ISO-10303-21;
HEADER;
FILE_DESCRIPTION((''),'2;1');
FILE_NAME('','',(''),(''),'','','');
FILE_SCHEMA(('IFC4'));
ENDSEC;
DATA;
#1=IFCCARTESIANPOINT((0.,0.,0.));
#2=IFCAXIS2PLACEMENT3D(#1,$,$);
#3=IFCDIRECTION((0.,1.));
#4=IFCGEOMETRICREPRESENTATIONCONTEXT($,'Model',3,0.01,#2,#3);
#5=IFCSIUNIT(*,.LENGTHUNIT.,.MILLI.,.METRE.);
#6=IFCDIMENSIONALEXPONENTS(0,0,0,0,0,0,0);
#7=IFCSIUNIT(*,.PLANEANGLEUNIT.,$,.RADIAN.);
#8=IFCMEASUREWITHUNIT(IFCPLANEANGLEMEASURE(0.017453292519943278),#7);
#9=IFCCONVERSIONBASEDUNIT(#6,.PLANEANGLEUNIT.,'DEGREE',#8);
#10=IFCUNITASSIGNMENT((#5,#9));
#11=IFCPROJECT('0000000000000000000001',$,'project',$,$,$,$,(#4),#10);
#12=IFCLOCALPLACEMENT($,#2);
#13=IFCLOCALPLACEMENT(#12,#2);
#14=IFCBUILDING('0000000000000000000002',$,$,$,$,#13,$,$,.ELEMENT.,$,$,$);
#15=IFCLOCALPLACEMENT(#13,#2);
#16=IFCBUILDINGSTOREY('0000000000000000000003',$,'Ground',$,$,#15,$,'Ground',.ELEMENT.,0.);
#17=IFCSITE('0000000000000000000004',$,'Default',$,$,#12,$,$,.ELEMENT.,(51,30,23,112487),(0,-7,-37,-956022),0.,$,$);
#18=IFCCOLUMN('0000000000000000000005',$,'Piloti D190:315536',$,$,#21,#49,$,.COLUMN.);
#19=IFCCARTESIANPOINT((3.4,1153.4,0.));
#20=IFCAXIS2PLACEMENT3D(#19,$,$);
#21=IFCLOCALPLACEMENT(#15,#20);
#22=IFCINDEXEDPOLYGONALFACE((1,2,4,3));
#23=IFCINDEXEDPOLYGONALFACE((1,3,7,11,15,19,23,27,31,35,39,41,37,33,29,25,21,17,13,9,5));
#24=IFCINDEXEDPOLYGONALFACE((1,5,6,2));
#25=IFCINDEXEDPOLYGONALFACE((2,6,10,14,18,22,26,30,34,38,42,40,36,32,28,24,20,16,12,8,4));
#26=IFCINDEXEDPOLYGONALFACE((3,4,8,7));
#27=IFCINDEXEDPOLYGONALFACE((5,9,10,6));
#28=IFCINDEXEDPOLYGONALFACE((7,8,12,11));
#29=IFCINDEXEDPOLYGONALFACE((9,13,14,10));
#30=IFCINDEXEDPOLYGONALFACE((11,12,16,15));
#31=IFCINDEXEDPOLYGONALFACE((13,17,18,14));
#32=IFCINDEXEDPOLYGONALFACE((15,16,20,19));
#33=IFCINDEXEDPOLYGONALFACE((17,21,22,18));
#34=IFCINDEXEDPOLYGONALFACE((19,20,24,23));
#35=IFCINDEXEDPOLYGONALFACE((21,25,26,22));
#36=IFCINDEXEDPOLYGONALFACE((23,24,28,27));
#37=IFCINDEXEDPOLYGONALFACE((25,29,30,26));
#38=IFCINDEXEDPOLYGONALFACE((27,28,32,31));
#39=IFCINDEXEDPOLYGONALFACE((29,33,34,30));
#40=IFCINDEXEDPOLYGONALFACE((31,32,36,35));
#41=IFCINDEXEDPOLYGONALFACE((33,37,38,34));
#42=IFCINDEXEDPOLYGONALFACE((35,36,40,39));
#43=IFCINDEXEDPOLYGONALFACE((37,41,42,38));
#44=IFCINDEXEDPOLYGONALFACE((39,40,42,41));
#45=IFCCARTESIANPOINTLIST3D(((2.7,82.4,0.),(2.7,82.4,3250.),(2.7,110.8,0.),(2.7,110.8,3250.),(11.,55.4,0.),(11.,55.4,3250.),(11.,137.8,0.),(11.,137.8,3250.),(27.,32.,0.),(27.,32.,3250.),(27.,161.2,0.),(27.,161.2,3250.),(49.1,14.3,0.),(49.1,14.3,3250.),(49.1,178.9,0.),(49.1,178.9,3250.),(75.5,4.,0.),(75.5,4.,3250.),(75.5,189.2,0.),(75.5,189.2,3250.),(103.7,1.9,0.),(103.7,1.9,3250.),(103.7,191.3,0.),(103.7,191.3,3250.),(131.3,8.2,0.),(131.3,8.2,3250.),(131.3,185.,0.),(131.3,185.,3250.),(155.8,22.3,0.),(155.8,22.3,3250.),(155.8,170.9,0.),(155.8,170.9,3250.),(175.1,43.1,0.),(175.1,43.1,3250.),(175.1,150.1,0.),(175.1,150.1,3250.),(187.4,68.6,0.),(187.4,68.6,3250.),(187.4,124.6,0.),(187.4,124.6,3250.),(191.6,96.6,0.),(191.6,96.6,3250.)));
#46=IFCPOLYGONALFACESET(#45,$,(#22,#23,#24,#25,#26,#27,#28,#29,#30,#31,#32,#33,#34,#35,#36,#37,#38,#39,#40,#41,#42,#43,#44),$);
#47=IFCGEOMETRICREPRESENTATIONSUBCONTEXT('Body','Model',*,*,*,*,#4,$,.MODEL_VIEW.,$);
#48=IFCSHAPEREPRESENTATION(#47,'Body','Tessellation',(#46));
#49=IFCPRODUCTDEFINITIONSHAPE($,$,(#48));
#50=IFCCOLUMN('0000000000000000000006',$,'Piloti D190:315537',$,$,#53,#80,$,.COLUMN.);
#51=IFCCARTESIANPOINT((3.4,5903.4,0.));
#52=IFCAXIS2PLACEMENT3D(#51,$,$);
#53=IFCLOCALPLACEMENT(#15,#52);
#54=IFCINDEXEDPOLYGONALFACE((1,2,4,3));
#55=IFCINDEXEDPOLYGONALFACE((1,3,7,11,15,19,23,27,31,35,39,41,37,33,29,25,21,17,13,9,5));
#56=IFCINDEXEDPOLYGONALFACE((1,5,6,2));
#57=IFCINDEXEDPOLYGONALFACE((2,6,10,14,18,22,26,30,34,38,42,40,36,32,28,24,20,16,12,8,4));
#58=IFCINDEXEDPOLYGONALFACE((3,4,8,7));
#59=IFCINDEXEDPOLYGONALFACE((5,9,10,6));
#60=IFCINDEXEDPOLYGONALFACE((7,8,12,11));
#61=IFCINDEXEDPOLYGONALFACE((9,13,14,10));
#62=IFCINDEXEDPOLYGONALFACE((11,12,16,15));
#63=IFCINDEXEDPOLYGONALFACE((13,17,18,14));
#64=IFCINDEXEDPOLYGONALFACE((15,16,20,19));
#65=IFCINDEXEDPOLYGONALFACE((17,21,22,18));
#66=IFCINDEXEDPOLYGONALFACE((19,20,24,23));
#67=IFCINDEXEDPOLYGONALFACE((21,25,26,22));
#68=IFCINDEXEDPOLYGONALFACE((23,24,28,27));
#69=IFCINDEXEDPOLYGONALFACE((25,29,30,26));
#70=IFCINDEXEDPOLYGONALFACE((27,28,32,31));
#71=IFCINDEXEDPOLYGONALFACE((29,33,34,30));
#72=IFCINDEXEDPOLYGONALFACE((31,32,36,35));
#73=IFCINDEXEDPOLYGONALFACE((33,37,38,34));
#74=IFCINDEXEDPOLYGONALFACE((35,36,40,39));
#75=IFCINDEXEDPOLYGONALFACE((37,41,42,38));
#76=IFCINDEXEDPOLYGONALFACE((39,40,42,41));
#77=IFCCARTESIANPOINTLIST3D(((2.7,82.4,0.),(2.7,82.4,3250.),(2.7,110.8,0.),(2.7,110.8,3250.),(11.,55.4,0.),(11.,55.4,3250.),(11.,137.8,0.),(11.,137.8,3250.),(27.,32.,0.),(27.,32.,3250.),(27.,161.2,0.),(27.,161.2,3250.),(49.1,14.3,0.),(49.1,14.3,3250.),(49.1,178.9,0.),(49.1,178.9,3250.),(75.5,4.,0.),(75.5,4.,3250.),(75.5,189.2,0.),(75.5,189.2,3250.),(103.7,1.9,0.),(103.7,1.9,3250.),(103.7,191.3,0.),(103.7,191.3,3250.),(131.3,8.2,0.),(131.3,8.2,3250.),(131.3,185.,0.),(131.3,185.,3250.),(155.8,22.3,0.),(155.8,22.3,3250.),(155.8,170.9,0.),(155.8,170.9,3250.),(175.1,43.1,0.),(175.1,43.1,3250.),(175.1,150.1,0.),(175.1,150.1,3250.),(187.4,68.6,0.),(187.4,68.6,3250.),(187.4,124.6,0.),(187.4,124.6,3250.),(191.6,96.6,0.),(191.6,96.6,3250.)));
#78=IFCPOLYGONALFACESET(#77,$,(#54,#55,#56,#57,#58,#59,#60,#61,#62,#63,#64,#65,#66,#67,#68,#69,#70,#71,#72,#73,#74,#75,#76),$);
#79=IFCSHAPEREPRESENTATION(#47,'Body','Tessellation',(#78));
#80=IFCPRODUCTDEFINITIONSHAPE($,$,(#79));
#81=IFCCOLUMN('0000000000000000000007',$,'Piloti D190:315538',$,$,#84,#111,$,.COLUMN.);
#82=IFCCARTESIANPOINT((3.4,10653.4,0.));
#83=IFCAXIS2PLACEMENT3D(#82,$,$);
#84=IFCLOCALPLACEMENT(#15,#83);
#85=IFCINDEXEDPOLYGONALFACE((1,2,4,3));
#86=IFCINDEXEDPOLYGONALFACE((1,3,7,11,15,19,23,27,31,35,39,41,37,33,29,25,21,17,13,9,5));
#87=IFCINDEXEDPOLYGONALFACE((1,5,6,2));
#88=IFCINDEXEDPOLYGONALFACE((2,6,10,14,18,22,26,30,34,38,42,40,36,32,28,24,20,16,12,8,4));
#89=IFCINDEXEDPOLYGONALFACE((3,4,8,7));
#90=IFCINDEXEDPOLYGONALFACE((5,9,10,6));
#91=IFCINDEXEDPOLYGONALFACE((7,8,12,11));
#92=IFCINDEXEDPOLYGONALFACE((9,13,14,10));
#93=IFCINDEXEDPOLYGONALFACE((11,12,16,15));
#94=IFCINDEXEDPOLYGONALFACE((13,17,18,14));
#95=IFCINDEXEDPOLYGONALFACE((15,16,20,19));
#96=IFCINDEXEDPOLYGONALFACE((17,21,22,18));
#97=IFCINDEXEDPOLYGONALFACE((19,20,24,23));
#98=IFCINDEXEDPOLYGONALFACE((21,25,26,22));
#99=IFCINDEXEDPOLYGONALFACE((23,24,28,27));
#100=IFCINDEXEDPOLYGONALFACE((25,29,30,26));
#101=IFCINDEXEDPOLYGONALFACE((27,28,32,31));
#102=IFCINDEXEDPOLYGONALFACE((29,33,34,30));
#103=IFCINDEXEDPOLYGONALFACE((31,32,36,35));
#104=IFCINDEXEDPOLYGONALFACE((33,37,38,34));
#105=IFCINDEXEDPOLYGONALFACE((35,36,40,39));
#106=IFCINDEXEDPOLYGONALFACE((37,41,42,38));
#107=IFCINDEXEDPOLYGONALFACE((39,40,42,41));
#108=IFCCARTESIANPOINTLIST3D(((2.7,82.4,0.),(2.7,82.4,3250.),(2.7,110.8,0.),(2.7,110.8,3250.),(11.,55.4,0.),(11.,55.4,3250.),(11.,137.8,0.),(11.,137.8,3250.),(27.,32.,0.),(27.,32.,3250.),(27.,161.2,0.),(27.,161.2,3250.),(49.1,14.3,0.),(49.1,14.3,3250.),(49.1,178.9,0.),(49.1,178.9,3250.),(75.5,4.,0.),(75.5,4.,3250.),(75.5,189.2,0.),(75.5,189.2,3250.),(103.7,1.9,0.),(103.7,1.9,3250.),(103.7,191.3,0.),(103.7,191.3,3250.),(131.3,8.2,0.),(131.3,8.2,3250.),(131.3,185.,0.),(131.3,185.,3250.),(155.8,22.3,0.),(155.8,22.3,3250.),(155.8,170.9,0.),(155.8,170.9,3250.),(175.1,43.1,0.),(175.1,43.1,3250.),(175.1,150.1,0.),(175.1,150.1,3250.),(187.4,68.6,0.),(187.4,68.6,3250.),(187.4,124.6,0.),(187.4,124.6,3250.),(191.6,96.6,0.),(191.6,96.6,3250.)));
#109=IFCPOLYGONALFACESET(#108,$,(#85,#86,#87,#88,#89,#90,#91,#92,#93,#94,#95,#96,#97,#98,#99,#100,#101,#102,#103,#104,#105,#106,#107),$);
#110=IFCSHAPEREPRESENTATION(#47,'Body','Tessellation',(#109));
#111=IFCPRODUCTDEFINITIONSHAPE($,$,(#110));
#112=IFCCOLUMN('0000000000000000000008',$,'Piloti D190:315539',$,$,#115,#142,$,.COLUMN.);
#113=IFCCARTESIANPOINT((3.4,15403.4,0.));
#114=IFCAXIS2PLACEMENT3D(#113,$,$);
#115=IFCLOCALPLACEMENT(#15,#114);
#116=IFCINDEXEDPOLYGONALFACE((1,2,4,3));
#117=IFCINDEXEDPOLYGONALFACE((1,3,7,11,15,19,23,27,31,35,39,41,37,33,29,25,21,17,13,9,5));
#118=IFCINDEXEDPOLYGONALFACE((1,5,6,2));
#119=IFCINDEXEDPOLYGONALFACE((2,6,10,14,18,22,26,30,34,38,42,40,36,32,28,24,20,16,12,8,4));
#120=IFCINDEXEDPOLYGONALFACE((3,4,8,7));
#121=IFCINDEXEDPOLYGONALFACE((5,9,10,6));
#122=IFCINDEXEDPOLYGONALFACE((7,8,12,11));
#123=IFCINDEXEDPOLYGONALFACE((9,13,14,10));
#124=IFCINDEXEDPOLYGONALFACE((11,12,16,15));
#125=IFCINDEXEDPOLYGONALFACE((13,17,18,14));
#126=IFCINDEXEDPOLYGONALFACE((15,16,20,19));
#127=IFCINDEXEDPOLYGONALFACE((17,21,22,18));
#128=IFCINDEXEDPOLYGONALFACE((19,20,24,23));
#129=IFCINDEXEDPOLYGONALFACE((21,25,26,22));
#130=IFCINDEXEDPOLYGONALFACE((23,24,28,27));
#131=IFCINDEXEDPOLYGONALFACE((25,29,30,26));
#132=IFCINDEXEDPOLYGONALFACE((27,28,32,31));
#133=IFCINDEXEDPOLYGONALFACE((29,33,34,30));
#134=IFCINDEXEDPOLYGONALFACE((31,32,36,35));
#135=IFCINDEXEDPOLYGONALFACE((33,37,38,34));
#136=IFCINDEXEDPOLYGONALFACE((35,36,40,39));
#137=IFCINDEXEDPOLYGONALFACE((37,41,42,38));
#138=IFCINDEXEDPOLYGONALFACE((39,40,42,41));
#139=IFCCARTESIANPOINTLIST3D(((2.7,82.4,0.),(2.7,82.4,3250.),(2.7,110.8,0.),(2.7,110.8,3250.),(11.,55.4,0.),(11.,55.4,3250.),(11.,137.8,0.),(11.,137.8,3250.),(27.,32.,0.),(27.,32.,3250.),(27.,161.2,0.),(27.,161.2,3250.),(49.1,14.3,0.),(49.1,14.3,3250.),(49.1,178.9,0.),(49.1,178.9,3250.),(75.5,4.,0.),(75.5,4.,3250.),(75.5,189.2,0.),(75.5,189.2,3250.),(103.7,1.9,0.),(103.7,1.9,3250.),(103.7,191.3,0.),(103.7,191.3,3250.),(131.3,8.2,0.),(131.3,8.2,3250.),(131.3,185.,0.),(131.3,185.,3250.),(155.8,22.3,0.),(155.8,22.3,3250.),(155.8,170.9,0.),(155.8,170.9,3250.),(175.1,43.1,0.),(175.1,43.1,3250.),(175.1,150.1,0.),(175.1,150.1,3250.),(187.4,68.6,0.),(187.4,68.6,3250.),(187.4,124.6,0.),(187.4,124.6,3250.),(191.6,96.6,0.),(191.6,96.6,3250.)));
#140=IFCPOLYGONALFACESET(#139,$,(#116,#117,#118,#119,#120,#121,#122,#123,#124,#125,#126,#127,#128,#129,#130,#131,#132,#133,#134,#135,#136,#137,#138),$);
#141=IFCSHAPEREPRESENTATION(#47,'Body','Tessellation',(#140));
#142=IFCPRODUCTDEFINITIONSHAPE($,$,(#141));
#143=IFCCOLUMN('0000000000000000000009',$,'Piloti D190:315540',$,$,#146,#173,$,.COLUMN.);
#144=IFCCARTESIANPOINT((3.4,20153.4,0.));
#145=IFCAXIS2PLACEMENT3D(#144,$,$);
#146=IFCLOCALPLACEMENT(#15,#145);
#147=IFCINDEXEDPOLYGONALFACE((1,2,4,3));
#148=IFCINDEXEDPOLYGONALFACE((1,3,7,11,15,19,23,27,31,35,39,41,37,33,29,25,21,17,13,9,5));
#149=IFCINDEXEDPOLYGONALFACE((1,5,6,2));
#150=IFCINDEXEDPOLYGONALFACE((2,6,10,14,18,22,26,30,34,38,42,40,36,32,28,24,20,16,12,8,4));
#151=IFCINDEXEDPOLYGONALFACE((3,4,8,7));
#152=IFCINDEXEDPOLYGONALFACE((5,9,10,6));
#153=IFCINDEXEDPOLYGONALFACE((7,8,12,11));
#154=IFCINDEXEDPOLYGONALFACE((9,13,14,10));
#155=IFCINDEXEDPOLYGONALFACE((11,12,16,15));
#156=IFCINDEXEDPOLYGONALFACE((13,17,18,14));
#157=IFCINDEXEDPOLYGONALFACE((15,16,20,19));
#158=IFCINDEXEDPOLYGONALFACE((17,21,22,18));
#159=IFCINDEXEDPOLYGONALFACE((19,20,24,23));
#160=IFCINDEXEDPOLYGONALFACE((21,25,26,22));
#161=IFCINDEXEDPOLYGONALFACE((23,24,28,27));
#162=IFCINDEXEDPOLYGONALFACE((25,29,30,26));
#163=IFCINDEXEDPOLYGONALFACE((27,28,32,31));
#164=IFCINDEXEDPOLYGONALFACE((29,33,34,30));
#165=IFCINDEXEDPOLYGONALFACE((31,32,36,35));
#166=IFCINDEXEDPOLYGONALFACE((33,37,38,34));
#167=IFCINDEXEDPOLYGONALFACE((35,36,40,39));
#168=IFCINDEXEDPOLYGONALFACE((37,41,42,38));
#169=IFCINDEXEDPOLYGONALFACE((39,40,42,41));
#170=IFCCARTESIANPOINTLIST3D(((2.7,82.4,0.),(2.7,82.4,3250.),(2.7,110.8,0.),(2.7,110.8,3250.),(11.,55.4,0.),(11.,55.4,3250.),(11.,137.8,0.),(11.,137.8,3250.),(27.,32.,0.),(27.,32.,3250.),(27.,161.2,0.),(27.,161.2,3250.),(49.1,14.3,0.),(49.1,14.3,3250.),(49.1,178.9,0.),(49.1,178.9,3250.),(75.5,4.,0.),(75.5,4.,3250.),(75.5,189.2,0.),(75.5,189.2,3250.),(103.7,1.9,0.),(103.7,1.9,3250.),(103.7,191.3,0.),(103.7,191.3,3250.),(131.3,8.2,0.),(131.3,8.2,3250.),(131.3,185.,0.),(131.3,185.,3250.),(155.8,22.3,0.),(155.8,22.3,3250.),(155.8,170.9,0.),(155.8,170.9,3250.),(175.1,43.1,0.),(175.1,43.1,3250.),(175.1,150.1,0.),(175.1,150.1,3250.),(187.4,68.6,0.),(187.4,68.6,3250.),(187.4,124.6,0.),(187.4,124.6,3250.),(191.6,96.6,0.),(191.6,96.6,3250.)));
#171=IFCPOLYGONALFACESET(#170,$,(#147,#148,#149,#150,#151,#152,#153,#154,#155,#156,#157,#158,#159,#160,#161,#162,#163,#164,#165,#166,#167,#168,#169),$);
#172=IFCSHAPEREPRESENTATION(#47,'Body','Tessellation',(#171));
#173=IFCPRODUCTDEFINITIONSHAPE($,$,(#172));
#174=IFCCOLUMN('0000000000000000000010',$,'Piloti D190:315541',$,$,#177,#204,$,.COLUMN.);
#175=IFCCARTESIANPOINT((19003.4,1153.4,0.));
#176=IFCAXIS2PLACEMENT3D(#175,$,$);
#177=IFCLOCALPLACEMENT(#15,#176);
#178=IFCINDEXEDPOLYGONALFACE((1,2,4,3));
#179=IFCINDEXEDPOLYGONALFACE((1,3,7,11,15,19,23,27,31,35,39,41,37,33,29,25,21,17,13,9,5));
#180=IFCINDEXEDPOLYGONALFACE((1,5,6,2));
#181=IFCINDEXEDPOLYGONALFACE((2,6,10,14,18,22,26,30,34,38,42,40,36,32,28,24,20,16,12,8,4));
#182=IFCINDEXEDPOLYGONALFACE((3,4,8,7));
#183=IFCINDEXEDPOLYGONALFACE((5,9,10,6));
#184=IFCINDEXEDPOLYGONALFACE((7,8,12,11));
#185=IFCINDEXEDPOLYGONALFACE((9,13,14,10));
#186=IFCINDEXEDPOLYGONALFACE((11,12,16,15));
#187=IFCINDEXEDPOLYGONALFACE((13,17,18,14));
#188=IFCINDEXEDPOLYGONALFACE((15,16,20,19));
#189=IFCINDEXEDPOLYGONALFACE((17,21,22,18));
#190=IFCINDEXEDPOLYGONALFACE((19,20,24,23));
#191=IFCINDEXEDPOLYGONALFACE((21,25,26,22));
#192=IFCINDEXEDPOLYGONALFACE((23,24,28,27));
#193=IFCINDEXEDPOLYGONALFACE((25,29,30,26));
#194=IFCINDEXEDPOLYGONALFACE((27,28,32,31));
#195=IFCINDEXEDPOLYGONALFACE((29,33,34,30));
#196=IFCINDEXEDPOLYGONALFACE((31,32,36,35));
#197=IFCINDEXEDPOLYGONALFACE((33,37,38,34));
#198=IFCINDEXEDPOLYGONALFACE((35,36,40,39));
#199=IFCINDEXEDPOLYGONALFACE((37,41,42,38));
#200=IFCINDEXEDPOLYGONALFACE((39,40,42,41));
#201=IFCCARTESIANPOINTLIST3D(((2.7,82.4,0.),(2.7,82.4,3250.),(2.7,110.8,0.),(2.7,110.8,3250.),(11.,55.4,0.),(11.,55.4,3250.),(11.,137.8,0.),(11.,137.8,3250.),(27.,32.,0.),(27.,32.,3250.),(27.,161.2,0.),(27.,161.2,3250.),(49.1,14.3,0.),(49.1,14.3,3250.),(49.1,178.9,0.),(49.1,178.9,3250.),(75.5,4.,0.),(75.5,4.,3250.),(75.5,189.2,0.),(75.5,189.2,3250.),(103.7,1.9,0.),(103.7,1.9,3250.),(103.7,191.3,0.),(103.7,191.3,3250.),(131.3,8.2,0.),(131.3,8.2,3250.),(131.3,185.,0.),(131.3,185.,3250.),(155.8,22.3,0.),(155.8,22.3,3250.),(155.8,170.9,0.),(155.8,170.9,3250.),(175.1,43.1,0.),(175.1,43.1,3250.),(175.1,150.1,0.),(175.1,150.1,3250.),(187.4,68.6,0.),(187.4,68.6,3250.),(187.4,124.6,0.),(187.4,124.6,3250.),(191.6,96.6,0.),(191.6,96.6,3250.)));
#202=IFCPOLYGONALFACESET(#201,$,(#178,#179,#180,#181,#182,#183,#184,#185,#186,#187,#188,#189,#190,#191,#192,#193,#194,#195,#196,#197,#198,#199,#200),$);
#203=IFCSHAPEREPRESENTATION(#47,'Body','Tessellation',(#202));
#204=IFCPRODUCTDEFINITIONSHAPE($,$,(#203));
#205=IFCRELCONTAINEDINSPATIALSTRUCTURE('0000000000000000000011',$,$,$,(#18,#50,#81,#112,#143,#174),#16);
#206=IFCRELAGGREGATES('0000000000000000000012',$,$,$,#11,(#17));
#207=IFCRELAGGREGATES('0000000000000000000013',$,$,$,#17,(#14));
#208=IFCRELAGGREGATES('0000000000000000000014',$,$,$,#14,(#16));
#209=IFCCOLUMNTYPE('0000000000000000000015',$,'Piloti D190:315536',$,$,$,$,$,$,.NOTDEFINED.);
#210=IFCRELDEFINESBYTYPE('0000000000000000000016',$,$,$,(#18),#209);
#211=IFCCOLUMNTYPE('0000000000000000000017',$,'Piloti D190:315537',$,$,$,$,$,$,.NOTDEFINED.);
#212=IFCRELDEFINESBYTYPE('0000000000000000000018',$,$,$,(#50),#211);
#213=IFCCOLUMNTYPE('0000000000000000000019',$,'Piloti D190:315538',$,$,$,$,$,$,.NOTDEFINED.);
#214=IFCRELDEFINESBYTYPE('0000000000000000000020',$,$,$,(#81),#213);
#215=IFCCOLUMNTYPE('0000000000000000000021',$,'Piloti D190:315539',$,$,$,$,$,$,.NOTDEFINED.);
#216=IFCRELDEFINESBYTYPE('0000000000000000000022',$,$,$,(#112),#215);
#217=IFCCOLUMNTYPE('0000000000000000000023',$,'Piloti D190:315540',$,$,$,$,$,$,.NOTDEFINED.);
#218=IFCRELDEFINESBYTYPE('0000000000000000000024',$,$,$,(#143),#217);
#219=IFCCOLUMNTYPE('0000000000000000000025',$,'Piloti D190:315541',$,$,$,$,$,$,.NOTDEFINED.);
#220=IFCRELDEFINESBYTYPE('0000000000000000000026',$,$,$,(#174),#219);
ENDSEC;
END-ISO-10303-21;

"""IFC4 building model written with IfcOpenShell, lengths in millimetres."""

from ifc_helpers import new_model, entity, si_unit, converted_unit, direction, frame, origin, origin_2d_with_axis, place, context, subcontext, project, spatial, circle, extrude, type_object, element, save


model = new_model("IFC4")

# Units and contexts
model_context = context("Model", 3, precision=0.01, world=origin(), true_north=direction((0.0, 1.0)))
body_context = subcontext(model_context, "Body", "Model", "MODEL_VIEW")
ifc_project = project(units=[si_unit("LENGTHUNIT", "METRE", prefix="MILLI"), converted_unit("PLANEANGLEUNIT", "DEGREE", entity("IfcPlaneAngleMeasure", 0.017453292519943278), si_unit("PLANEANGLEUNIT", "RADIAN"), dimensions=[0, 0, 0, 0, 0, 0, 0])], contexts=[model_context])

# Site, building, storey
site_placement = place(None, origin())
site = spatial("IfcSite", under=ifc_project, at=site_placement, Name="Default", CompositionType="ELEMENT", RefLatitude=(51, 30, 23, 112487), RefLongitude=(0, -7, -37, -956022), RefElevation=0.0)
building_placement = place(site_placement, origin())
building = spatial("IfcBuilding", under=site, at=building_placement, CompositionType="ELEMENT")
storey_placement = place(building_placement, origin())
storey = spatial("IfcBuildingStorey", under=building, at=storey_placement, Name="Ground", LongName="Ground", CompositionType="ELEMENT", Elevation=0.0)

# Columns
column_type_1 = type_object("IfcColumnType", Name="Piloti D190:315536", PredefinedType="NOTDEFINED")
column_1_placement = place(storey_placement, frame((3.4, 1153.4, 0.0)))
element("IfcColumn", 1, at=column_1_placement, inside=storey, type_object=column_type_1, Name="Piloti D190:315536", PredefinedType="COLUMN", context=body_context, shape_type="SweptSolid", body=[
    extrude(circle(Radius=95.0, at=origin_2d_with_axis()), frame((96.6, 96.6, 0.0)), (0.0, 0.0, 1.0), 3250.0),
])
column_type_2 = type_object("IfcColumnType", Name="Piloti D190:315537", PredefinedType="NOTDEFINED")
column_2_placement = place(storey_placement, frame((3.4, 5903.4, 0.0)))
element("IfcColumn", 2, at=column_2_placement, inside=storey, type_object=column_type_2, Name="Piloti D190:315537", PredefinedType="COLUMN", context=body_context, shape_type="SweptSolid", body=[
    extrude(circle(Radius=95.0, at=origin_2d_with_axis()), frame((96.6, 96.6, 0.0)), (0.0, 0.0, 1.0), 3250.0),
])
column_type_3 = type_object("IfcColumnType", Name="Piloti D190:315538", PredefinedType="NOTDEFINED")
column_3_placement = place(storey_placement, frame((3.4, 10653.4, 0.0)))
element("IfcColumn", 3, at=column_3_placement, inside=storey, type_object=column_type_3, Name="Piloti D190:315538", PredefinedType="COLUMN", context=body_context, shape_type="SweptSolid", body=[
    extrude(circle(Radius=95.0, at=origin_2d_with_axis()), frame((96.6, 96.6, 0.0)), (0.0, 0.0, 1.0), 3250.0),
])
column_type_4 = type_object("IfcColumnType", Name="Piloti D190:315539", PredefinedType="NOTDEFINED")
column_4_placement = place(storey_placement, frame((3.4, 15403.4, 0.0)))
element("IfcColumn", 4, at=column_4_placement, inside=storey, type_object=column_type_4, Name="Piloti D190:315539", PredefinedType="COLUMN", context=body_context, shape_type="SweptSolid", body=[
    extrude(circle(Radius=95.0, at=origin_2d_with_axis()), frame((96.6, 96.6, 0.0)), (0.0, 0.0, 1.0), 3250.0),
])
column_type_5 = type_object("IfcColumnType", Name="Piloti D190:315540", PredefinedType="NOTDEFINED")
column_5_placement = place(storey_placement, frame((3.4, 20153.4, 0.0)))
element("IfcColumn", 5, at=column_5_placement, inside=storey, type_object=column_type_5, Name="Piloti D190:315540", PredefinedType="COLUMN", context=body_context, shape_type="SweptSolid", body=[
    extrude(circle(Radius=95.0, at=origin_2d_with_axis()), frame((96.6, 96.6, 0.0)), (0.0, 0.0, 1.0), 3250.0),
])
column_type_6 = type_object("IfcColumnType", Name="Piloti D190:315541", PredefinedType="NOTDEFINED")
column_6_placement = place(storey_placement, frame((19003.4, 1153.4, 0.0)))
element("IfcColumn", 6, at=column_6_placement, inside=storey, type_object=column_type_6, Name="Piloti D190:315541", PredefinedType="COLUMN", context=body_context, shape_type="SweptSolid", body=[
    extrude(circle(Radius=95.0, at=origin_2d_with_axis()), frame((96.6, 96.6, 0.0)), (0.0, 0.0, 1.0), 3250.0),
])

save(model, "model.ifc")
